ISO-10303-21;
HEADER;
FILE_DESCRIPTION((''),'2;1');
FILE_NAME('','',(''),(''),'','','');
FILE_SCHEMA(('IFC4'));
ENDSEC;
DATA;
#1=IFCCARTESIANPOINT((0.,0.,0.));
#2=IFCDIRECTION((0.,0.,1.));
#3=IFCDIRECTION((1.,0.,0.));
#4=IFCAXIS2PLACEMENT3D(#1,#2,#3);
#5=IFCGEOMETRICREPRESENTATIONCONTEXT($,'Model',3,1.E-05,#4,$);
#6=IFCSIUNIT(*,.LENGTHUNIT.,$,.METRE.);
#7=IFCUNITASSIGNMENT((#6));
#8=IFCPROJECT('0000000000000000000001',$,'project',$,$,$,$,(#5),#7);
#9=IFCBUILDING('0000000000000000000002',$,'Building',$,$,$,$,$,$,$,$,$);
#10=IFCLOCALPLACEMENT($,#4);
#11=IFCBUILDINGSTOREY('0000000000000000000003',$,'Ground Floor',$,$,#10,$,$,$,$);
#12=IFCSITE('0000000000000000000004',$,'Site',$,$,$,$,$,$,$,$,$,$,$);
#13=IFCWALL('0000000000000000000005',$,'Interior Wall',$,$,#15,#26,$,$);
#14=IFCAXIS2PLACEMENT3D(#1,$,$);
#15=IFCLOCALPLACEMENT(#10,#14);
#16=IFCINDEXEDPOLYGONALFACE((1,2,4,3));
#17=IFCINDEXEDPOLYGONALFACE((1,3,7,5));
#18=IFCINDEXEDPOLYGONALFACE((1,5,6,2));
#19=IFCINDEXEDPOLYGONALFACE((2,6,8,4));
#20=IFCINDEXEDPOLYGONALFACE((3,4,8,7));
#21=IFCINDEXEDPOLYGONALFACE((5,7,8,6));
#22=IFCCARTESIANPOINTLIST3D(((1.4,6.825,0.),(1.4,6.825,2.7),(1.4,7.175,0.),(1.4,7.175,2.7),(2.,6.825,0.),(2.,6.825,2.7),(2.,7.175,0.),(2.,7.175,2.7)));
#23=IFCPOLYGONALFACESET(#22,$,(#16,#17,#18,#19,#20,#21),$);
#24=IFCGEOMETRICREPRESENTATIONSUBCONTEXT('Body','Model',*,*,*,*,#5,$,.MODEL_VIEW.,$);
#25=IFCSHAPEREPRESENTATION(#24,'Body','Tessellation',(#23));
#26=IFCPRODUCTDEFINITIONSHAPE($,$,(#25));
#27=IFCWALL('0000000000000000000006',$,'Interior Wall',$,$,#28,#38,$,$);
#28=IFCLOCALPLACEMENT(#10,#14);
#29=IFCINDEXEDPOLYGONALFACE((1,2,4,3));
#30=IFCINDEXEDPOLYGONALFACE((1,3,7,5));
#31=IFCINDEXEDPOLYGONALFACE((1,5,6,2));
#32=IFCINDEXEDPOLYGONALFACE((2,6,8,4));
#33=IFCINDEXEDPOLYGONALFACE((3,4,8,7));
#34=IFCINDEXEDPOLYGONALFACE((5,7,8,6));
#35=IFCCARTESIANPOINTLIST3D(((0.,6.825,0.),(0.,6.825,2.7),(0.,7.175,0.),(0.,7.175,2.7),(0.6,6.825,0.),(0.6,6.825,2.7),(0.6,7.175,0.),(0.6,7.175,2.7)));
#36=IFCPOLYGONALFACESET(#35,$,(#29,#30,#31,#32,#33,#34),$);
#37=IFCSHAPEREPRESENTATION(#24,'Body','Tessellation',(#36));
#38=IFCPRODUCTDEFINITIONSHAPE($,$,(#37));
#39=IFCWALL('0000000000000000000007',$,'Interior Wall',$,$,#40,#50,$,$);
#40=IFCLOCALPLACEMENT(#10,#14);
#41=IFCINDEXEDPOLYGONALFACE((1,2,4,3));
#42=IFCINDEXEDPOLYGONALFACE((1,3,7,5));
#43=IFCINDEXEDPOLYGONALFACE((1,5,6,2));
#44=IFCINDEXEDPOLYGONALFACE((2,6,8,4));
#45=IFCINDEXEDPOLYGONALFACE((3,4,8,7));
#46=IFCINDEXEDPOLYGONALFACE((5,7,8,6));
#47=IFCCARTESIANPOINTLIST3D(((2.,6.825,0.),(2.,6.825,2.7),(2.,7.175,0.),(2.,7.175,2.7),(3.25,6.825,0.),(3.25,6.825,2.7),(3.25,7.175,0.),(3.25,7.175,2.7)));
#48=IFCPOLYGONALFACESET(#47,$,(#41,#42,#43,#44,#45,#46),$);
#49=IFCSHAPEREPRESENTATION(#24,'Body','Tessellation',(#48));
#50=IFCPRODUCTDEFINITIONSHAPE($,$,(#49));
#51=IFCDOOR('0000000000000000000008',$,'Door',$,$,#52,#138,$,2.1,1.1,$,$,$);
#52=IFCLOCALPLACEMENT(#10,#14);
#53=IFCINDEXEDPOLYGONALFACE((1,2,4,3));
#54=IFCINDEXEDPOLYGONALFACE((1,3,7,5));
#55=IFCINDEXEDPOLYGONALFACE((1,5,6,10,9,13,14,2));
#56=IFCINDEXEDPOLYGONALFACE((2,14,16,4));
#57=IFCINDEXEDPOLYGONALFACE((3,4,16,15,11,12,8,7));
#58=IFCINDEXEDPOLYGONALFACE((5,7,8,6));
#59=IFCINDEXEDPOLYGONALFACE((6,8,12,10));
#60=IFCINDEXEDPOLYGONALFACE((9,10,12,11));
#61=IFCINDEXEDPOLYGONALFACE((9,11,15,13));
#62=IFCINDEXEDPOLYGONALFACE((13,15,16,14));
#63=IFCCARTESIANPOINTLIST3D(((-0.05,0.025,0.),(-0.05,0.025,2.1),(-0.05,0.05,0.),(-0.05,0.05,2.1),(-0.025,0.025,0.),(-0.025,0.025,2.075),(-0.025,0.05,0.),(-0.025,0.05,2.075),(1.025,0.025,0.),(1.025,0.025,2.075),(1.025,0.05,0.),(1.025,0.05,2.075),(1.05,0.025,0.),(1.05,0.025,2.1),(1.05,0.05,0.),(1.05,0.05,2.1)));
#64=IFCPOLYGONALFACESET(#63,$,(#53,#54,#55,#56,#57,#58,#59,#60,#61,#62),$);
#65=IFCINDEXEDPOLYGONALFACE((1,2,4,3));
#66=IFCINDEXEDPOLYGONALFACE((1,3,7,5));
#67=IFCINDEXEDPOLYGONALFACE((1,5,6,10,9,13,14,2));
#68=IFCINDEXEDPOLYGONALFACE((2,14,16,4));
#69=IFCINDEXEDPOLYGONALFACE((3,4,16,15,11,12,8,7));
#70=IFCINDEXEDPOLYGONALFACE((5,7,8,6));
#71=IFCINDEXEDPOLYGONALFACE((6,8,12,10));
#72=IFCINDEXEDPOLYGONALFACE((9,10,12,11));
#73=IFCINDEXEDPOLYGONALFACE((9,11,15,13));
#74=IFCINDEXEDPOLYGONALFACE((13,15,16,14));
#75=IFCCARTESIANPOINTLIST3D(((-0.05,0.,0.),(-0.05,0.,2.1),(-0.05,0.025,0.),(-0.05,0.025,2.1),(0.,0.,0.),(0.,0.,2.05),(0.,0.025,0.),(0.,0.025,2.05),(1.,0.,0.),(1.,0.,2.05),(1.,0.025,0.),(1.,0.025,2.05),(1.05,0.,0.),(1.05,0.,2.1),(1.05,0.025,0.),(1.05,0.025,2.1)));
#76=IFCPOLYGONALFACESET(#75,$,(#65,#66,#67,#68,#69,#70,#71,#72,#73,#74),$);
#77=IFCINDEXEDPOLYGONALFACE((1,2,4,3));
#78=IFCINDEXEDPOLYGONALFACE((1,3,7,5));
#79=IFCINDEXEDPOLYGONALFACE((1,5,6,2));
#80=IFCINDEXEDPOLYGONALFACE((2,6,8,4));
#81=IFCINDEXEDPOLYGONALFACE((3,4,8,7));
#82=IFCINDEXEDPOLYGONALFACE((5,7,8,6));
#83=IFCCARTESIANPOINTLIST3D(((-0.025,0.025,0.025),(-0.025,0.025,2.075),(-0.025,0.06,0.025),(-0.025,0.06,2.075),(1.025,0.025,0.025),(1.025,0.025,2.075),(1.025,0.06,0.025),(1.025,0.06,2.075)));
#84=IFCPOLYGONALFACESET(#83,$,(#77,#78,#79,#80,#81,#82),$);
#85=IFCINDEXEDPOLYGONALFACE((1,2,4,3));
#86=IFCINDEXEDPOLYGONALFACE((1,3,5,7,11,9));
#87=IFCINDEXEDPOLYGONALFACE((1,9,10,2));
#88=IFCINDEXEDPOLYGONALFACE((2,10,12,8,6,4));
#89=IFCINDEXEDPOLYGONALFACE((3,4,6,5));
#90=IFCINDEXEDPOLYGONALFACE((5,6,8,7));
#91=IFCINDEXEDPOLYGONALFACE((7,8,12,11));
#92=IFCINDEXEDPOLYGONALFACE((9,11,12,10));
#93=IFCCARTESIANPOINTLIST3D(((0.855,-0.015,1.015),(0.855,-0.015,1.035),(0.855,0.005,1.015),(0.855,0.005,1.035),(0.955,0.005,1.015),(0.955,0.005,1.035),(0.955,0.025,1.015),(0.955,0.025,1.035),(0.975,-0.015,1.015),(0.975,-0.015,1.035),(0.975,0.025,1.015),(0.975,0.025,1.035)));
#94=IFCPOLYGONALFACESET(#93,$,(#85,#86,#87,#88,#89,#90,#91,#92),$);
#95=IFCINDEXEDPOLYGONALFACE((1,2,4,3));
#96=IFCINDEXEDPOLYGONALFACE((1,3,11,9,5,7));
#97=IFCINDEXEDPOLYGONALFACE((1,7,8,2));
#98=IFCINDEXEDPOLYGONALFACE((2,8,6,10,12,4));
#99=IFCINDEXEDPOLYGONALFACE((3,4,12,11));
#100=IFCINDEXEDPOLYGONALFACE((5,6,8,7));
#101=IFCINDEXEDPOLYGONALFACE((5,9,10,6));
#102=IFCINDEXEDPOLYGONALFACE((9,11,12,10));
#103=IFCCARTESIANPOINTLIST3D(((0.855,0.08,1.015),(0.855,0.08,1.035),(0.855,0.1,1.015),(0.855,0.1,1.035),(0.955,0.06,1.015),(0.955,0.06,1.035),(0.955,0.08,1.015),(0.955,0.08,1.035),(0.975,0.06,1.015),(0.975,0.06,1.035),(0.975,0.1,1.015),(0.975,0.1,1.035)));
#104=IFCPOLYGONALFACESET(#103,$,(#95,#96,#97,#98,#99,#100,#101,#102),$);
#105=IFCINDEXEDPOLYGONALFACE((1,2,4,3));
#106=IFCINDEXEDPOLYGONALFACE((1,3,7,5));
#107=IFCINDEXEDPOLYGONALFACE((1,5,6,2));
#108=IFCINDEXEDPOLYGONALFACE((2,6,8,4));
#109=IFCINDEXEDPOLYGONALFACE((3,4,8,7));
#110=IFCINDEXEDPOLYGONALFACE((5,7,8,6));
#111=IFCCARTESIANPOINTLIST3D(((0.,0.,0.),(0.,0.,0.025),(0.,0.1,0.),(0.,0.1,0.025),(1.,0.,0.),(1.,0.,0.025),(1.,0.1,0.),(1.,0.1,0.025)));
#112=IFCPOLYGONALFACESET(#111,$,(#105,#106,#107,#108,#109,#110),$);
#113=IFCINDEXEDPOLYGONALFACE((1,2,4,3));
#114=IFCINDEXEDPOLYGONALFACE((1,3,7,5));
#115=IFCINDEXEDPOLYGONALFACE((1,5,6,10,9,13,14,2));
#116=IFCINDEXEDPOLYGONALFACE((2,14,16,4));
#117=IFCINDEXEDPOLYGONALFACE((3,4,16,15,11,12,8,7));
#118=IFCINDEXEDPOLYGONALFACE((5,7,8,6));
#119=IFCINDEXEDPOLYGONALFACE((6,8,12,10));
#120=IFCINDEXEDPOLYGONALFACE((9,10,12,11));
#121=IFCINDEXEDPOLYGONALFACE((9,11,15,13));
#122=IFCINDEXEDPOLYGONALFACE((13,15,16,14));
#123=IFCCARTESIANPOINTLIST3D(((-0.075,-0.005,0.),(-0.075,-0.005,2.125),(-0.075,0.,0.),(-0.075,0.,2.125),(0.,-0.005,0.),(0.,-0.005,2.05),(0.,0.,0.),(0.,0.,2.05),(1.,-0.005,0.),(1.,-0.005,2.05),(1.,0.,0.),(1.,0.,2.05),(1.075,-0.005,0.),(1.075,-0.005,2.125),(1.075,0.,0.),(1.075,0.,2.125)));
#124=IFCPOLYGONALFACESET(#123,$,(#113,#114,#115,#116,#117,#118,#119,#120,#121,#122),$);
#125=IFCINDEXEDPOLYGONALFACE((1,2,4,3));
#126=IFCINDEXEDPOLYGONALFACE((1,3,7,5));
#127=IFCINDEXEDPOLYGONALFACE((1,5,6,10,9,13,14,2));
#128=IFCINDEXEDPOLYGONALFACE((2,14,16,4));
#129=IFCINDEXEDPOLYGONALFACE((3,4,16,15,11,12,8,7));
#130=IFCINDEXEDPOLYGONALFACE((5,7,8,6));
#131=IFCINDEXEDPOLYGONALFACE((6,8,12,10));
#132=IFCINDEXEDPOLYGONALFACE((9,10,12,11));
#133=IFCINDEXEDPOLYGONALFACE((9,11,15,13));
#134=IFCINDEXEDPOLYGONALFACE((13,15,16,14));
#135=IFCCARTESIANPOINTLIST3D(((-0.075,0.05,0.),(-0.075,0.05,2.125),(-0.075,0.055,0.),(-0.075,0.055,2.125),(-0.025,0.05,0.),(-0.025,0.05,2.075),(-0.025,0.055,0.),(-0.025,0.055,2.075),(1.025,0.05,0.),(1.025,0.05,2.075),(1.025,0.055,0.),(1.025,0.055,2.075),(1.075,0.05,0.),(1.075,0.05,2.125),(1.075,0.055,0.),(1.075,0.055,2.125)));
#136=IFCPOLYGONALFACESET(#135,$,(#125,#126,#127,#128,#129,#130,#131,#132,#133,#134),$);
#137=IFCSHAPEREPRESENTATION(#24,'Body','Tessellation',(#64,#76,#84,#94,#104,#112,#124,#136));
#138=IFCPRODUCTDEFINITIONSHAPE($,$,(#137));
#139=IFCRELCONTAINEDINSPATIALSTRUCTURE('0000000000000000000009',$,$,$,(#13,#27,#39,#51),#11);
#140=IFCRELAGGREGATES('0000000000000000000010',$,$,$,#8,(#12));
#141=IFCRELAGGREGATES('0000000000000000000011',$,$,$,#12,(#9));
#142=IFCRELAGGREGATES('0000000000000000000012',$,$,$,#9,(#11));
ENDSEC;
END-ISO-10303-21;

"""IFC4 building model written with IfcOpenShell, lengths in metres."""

from ifc_helpers import new_model, si_unit, frame, origin_with_axes, place, context, subcontext, project, spatial, line, indexed_curve, outline, extrude, element, save


model = new_model("IFC4")

# Units and contexts
model_context = context("Model", 3, precision=1e-05, world=origin_with_axes())
body_context = subcontext(model_context, "Body", "Model", "MODEL_VIEW")
ifc_project = project(units=[si_unit("LENGTHUNIT", "METRE")], contexts=[model_context])

# Site, building, storey
site = spatial("IfcSite", under=ifc_project, Name="Site")
building = spatial("IfcBuilding", under=site, Name="Building")
storey_placement = place(None, origin_with_axes())
storey = spatial("IfcBuildingStorey", under=building, at=storey_placement, Name="Ground Floor")

# Walls
for number, where, z_axis, x_axis, name in (
    (1, (2.0, 7.0, 0.0), (0.0, 0.0, 1.0), (-1.0, 0.0, 0.0), "Interior Wall"),
    (2, (0.6, 7.0, 0.0), (0.0, 0.0, 1.0), (-1.0, 0.0, 0.0), "Interior Wall"),
):
    element("IfcWall", number, at=place(storey_placement, frame(where, z_axis=z_axis, x_axis=x_axis)), inside=storey, Name=name, context=body_context, shape_type="SweptSolid", body=[
        extrude(outline(indexed_curve([(0.0, 0.0), (0.0, 0.35), (0.6, 0.35), (0.6, 0.0), (0.0, 0.0)], self_intersect=False)), frame((0.0, -0.175, 0.0), z_axis=(0.0, 0.0, 1.0), x_axis=(1.0, 0.0, 0.0)), (0.0, 0.0, 1.0), 2.7),
    ])
wall_1_placement = place(storey_placement, frame((3.25, 7.0, 0.0), z_axis=(0.0, 0.0, 1.0), x_axis=(-1.0, 0.0, 0.0)))
element("IfcWall", 3, at=wall_1_placement, inside=storey, Name="Interior Wall", context=body_context, shape_type="SweptSolid", body=[
    extrude(outline(indexed_curve([(0.0, 0.0), (0.0, 0.35), (1.25, 0.35), (1.25, 0.0), (0.0, 0.0)], self_intersect=False)), frame((0.0, -0.175, 0.0), z_axis=(0.0, 0.0, 1.0), x_axis=(1.0, 0.0, 0.0)), (0.0, 0.0, 1.0), 2.7),
])

# Door
door_1_placement = place(storey_placement, frame((-0.05, 0.0, 0.0), z_axis=(0.0, 0.0, 1.0), x_axis=(1.0, 0.0, 0.0)))
element("IfcDoor", 4, at=door_1_placement, inside=storey, Name="Door", OverallHeight=2.1, OverallWidth=1.1, context=body_context, shape_type="SweptSolid", body=[
    extrude(outline(indexed_curve([(0.0, 0.0), (0.0, 2.1), (1.1, 2.1), (1.1, 0.0), (1.075, 0.0), (1.075, 2.075), (0.025, 2.075), (0.025, 0.0)], segments=[line(1, 2, 3, 4, 5, 6, 7, 8, 1)])), frame((0.0, 0.025, 0.0), z_axis=(0.0, -1.0, 0.0), x_axis=(1.0, 0.0, 0.0)), (0.0, 0.0, -1.0), 0.025),
    extrude(outline(indexed_curve([(0.0, 0.0), (0.0, 2.1), (1.1, 2.1), (1.1, 0.0), (1.05, 0.0), (1.05, 2.05), (0.05, 2.05), (0.05, 0.0)], segments=[line(1, 2, 3, 4, 5, 6, 7, 8, 1)])), frame((0.0, 0.0, 0.0), z_axis=(0.0, -1.0, 0.0), x_axis=(1.0, 0.0, 0.0)), (0.0, 0.0, -1.0), 0.025),
    extrude(outline(indexed_curve([(0.0, 0.0), (1.05, 0.0), (1.05, 0.035), (0.0, 0.035)], segments=[line(1, 2, 3, 4, 1)])), frame((0.025, 0.025, 0.025), z_axis=(0.0, 0.0, 1.0), x_axis=(1.0, 0.0, 0.0)), (0.0, 0.0, 1.0), 2.05),
    extrude(outline(indexed_curve([(0.0, 0.0), (0.0, -0.04), (-0.12, -0.04), (-0.12, -0.02), (-0.02, -0.02), (-0.02, 0.0)], segments=[line(1, 2, 3, 4, 5, 6, 1)])), frame((1.025, 0.025, 1.015), z_axis=(0.0, 0.0, 1.0), x_axis=(1.0, 0.0, 0.0)), (0.0, 0.0, 1.0), 0.02),
    extrude(outline(indexed_curve([(0.0, 0.0), (0.0, 0.04), (-0.12, 0.04), (-0.12, 0.02), (-0.02, 0.02), (-0.02, 0.0)], segments=[line(1, 2, 3, 4, 5, 6, 1)])), frame((1.025, 0.06, 1.015), z_axis=(0.0, 0.0, 1.0), x_axis=(1.0, 0.0, 0.0)), (0.0, 0.0, 1.0), 0.02),
    extrude(outline(indexed_curve([(0.0, 0.0), (1.0, 0.0), (1.0, 0.1), (0.0, 0.1)], segments=[line(1, 2, 3, 4, 1)])), frame((0.05, 0.0, 0.0), z_axis=(0.0, 0.0, 1.0), x_axis=(1.0, 0.0, 0.0)), (0.0, 0.0, 1.0), 0.025),
    extrude(outline(indexed_curve([(0.0, 0.0), (0.0, 2.125), (1.15, 2.125), (1.15, 0.0), (1.075, 0.0), (1.075, 2.05), (0.075, 2.05), (0.075, 0.0)], segments=[line(1, 2, 3, 4, 5, 6, 7, 8, 1)])), frame((-0.025, -0.005, 0.0), z_axis=(0.0, -1.0, 0.0), x_axis=(1.0, 0.0, 0.0)), (0.0, 0.0, -1.0), 0.005),
    extrude(outline(indexed_curve([(0.0, 0.0), (0.0, 2.125), (1.15, 2.125), (1.15, 0.0), (1.1, 0.0), (1.1, 2.075), (0.05, 2.075), (0.05, 0.0)], segments=[line(1, 2, 3, 4, 5, 6, 7, 8, 1)])), frame((-0.025, 0.05, 0.0), z_axis=(0.0, -1.0, 0.0), x_axis=(1.0, 0.0, 0.0)), (0.0, 0.0, -1.0), 0.005),
])

save(model, "model.ifc")
